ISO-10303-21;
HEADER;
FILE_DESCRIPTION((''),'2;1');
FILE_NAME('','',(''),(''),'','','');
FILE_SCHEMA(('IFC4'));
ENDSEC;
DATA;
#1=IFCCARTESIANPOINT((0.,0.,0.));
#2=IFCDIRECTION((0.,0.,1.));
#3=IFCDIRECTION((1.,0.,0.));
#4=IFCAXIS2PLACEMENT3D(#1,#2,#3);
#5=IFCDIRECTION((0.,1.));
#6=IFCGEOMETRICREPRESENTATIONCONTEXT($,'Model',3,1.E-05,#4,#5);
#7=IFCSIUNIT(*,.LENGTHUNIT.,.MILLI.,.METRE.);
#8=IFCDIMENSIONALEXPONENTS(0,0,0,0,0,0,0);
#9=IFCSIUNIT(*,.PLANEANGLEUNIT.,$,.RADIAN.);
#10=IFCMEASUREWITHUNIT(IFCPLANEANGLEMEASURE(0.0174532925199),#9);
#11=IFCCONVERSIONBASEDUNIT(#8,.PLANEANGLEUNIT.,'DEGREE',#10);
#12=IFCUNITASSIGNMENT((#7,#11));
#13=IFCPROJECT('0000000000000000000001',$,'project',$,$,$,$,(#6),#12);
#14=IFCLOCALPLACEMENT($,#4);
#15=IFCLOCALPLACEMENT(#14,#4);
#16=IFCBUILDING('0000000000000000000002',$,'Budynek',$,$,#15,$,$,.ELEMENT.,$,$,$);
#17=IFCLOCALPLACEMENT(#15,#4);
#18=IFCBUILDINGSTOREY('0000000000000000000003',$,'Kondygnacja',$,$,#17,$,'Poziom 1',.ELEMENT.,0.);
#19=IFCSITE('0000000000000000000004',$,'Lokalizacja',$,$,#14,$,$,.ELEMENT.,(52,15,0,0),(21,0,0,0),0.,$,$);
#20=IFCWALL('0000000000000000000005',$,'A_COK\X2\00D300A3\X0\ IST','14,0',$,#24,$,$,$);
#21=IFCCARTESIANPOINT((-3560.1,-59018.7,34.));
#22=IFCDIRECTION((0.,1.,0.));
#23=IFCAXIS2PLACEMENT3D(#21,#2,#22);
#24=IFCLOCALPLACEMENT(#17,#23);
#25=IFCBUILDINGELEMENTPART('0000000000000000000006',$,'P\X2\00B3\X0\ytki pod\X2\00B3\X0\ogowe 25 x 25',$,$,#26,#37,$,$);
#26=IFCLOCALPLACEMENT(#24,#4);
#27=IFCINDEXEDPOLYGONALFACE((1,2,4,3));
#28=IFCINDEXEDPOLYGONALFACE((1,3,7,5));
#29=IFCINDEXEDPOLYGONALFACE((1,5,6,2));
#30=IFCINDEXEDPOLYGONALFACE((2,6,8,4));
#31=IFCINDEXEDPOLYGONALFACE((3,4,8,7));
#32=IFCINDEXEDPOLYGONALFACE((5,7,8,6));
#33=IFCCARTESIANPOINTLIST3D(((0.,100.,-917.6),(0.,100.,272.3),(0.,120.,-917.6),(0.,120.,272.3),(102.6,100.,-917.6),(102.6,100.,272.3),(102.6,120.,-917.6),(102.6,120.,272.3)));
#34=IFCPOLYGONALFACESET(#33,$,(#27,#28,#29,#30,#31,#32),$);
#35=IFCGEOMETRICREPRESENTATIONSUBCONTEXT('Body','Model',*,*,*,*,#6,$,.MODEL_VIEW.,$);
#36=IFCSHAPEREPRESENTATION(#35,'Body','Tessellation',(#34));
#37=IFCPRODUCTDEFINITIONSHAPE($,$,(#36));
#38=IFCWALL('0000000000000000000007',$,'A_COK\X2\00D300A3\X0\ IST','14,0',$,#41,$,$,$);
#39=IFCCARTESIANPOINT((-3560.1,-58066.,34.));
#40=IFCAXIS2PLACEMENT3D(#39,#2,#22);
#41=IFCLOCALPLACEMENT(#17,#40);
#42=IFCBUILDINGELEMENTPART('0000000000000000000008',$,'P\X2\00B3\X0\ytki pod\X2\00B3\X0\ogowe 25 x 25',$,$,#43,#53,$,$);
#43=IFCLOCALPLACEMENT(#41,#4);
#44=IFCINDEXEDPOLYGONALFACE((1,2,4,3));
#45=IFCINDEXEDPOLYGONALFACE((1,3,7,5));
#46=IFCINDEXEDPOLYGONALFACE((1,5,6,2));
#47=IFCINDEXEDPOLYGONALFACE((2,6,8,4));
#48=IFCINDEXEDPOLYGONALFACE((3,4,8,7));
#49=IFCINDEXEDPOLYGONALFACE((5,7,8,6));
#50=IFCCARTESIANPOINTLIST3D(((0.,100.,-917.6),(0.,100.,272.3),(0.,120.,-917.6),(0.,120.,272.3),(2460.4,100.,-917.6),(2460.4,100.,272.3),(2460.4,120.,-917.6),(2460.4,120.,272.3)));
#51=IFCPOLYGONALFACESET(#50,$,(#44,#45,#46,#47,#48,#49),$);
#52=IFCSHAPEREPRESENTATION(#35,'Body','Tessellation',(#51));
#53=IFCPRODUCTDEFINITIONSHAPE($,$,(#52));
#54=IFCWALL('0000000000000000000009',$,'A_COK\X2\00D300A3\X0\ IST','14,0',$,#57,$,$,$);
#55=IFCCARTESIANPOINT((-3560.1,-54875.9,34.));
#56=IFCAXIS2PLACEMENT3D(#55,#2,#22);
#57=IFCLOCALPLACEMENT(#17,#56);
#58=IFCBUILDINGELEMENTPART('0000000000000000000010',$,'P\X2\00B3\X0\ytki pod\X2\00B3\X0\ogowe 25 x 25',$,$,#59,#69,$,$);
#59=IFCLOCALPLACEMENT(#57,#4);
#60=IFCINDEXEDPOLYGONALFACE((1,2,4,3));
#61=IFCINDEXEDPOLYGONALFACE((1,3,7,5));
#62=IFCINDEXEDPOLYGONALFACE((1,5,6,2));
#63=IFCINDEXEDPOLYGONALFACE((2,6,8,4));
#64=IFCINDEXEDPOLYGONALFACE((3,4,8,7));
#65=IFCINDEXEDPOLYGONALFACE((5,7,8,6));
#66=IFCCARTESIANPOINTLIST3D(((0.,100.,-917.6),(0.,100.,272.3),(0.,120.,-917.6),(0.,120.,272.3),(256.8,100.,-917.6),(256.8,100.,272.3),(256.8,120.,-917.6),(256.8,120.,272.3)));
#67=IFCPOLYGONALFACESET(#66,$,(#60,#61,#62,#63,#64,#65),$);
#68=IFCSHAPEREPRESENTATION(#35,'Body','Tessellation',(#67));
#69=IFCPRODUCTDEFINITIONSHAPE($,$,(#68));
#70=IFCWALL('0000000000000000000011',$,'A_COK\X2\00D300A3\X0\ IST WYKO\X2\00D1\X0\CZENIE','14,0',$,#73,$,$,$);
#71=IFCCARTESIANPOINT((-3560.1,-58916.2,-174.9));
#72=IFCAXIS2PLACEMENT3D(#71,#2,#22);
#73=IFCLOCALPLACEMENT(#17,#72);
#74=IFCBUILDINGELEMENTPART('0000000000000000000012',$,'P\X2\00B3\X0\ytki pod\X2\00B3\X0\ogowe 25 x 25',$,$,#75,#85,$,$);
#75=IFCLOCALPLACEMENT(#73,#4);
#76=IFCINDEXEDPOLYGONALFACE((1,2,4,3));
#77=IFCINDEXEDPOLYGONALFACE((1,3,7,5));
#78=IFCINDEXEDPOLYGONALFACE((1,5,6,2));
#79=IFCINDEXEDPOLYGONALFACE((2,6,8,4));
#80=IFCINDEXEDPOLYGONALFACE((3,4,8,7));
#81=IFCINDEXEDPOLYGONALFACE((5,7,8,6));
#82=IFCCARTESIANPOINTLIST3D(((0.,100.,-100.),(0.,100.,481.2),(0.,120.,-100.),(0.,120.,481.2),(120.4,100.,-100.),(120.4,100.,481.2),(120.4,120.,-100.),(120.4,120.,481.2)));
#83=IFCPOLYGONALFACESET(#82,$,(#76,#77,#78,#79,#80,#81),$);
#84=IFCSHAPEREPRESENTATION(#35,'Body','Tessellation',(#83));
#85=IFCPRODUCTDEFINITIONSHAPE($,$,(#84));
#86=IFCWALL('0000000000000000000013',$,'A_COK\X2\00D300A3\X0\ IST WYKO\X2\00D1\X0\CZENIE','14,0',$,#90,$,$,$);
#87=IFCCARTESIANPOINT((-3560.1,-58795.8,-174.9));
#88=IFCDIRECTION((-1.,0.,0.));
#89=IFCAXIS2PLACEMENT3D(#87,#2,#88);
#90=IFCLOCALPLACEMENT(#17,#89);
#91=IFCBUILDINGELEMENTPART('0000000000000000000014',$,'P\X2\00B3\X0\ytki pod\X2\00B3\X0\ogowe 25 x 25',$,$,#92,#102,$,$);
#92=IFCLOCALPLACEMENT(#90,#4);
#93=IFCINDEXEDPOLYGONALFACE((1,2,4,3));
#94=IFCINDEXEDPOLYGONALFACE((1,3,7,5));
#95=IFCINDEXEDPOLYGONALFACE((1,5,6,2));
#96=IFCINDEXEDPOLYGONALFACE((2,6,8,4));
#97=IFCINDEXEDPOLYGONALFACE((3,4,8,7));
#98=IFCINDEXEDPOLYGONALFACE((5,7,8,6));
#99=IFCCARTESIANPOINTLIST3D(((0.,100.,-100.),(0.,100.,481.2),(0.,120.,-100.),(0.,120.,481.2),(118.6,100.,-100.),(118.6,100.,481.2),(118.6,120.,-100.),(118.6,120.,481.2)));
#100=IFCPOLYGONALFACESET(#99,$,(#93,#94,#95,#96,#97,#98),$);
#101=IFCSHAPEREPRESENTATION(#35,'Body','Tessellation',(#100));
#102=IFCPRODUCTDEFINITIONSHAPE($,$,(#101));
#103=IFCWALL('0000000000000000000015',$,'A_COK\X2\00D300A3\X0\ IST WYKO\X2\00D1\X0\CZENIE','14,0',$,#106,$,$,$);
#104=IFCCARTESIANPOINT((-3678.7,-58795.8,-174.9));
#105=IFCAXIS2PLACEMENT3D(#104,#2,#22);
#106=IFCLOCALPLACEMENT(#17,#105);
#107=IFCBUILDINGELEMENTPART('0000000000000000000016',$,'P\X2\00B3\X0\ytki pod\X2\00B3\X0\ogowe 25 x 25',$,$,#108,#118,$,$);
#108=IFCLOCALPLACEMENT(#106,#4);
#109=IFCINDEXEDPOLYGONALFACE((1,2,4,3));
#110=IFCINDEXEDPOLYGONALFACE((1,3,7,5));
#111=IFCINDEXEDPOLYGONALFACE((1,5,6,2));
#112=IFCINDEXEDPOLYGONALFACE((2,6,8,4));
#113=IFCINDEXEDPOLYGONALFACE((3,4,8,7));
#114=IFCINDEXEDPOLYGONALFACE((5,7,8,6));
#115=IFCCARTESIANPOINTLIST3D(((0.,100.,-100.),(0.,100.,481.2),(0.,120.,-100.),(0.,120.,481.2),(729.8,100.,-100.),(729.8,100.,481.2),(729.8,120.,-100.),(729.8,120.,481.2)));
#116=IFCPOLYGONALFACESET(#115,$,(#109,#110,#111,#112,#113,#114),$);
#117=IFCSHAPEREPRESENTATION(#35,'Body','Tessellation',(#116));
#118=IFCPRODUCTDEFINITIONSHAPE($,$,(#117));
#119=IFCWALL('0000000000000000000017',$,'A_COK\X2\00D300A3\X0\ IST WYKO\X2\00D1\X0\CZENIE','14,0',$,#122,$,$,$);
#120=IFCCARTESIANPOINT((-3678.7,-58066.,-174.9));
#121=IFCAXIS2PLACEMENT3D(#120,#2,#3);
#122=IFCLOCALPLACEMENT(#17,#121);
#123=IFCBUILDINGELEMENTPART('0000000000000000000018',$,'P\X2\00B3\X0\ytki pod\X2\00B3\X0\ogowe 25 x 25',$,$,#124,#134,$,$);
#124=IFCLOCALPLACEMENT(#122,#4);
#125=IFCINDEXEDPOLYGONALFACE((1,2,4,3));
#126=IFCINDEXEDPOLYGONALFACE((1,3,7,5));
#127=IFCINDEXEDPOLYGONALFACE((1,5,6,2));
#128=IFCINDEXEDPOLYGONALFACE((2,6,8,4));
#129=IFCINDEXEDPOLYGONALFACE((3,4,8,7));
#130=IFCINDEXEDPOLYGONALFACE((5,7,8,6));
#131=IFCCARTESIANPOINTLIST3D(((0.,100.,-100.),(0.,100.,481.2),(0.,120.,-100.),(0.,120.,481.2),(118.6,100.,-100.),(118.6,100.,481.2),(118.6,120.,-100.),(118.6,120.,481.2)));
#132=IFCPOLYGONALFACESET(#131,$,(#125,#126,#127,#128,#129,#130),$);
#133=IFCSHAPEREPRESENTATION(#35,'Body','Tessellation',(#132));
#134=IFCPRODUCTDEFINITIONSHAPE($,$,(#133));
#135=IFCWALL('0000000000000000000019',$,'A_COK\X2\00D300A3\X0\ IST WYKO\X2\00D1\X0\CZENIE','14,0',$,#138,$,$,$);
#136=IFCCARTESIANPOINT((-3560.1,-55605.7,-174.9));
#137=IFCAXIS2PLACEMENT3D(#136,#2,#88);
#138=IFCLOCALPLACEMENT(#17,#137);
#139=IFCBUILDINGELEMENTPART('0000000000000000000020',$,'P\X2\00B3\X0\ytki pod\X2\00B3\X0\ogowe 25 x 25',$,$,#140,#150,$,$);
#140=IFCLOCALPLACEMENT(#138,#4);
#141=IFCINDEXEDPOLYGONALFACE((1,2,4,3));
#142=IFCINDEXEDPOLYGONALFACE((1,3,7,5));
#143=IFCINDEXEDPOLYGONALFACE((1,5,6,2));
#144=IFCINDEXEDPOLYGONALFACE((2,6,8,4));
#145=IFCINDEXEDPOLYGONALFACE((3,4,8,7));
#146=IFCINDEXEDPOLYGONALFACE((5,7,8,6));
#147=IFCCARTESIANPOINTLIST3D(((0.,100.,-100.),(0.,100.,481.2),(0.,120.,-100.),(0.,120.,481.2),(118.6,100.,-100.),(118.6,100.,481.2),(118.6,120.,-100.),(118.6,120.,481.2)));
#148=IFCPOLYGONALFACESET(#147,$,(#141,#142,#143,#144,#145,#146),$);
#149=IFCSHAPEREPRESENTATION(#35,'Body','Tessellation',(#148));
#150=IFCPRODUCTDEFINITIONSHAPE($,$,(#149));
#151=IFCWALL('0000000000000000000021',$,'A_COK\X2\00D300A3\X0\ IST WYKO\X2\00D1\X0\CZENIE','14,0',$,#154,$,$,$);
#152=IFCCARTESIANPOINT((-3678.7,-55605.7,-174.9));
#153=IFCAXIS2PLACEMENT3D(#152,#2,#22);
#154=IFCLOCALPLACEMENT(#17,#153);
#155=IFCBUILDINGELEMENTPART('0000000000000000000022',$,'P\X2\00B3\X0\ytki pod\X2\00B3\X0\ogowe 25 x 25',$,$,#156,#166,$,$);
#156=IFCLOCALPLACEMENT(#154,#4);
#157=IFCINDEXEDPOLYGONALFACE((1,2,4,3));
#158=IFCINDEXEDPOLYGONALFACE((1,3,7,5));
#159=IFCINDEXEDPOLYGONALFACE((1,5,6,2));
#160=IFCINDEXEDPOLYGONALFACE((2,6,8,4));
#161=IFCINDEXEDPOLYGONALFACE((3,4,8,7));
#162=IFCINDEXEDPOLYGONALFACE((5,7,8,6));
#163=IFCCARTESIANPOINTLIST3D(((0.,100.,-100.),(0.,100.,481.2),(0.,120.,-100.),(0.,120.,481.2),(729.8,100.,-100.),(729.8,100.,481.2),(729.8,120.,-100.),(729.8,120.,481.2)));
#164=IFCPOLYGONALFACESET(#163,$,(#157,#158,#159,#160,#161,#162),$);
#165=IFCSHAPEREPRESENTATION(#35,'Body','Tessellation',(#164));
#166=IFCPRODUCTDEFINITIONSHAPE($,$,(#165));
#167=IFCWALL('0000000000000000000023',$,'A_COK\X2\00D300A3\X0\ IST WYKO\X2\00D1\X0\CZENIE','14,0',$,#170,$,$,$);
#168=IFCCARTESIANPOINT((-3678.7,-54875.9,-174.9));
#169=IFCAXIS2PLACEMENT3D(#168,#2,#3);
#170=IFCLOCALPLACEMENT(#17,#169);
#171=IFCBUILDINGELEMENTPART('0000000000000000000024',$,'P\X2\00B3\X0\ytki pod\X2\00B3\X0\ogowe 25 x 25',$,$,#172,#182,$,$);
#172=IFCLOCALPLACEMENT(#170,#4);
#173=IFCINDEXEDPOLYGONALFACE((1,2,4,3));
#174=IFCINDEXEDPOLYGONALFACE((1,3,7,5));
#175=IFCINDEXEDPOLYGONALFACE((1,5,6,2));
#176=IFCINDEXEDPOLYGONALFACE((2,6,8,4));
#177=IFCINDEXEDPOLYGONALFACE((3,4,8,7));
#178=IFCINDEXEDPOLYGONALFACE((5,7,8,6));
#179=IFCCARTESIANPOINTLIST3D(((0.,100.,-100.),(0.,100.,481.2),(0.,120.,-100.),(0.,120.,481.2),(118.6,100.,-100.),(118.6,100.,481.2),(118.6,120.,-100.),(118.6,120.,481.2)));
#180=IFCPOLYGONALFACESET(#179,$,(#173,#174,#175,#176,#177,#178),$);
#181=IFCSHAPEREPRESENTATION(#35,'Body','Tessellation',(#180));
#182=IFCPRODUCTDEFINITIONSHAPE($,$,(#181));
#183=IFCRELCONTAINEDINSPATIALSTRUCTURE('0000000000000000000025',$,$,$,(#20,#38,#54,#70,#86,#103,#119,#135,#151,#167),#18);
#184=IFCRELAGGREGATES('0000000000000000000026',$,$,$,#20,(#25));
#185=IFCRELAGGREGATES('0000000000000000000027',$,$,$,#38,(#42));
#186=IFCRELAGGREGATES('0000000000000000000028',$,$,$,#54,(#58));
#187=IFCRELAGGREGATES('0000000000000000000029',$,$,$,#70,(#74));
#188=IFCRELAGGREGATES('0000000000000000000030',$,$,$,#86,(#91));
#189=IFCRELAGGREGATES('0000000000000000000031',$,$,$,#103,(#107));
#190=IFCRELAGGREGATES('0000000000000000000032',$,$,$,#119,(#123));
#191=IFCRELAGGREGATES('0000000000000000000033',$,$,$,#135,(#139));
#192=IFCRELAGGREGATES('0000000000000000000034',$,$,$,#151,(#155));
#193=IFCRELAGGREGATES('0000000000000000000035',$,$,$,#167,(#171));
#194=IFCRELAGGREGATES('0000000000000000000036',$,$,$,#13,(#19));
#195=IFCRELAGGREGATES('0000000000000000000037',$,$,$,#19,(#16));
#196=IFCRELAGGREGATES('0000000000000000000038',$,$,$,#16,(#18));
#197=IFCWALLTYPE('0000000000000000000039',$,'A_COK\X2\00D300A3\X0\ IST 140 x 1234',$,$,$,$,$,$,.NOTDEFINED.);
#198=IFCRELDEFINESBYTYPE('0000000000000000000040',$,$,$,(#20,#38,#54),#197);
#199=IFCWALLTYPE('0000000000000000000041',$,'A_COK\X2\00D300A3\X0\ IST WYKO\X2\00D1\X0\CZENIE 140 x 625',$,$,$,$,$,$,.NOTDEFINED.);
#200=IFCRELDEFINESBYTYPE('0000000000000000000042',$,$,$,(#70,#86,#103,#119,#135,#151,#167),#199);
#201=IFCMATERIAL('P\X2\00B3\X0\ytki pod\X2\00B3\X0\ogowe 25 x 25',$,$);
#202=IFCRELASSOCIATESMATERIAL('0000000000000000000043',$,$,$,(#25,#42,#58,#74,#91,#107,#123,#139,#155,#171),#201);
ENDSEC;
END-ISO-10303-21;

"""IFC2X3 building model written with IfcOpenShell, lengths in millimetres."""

from ifc_helpers import new_model, entity, si_unit, converted_unit, direction, frame, origin_with_axes, place, context, subcontext, project, spatial, polyline, outline, extrude, material, type_object, element, aggregate, save


model = new_model("IFC2X3")

# Units and contexts
model_context = context("Model", 3, precision=1e-05, world=origin_with_axes(), true_north=direction((0.0, 1.0)))
body_context = subcontext(model_context, "Body", "Model", "MODEL_VIEW")
ifc_project = project(units=[si_unit("LENGTHUNIT", "METRE", prefix="MILLI"), converted_unit("PLANEANGLEUNIT", "DEGREE", entity("IfcPlaneAngleMeasure", 0.0174532925199), si_unit("PLANEANGLEUNIT", "RADIAN"), dimensions=[0, 0, 0, 0, 0, 0, 0])], contexts=[model_context])

# Site, building, storey
site_placement = place(None, origin_with_axes())
site = spatial("IfcSite", under=ifc_project, at=site_placement, Name="Lokalizacja", CompositionType="ELEMENT", RefLatitude=(52, 15, 0, 0), RefLongitude=(21, 0, 0, 0), RefElevation=0.0)
building_placement = place(site_placement, origin_with_axes())
building = spatial("IfcBuilding", under=site, at=building_placement, Name="Budynek", CompositionType="ELEMENT")
storey_placement = place(building_placement, origin_with_axes())
storey = spatial("IfcBuildingStorey", under=building, at=storey_placement, Name="Kondygnacja", LongName="Poziom 1", CompositionType="ELEMENT", Elevation=0.0)

# Walls, building element parts
wall_type_1 = type_object("IfcWallType", Name="A_COKÓ£ IST 140 x 1234", PredefinedType="NOTDEFINED")
wall_1_placement = place(storey_placement, frame((-3560.1, -59018.7, 34.0), z_axis=(0.0, 0.0, 1.0), x_axis=(0.0, 1.0, 0.0)))
wall_1 = element("IfcWall", 1, at=wall_1_placement, inside=storey, type_object=wall_type_1, Name="A_COKÓ£ IST", Description="14,0")
ifc_material_1 = material(Name="P³ytki pod³ogowe 25 x 25")
building_element_part_1_placement = place(wall_1_placement, origin_with_axes())
building_element_part_1 = element("IfcBuildingElementPart", 2, at=building_element_part_1_placement, material=ifc_material_1, Name="P³ytki pod³ogowe 25 x 25", context=body_context, shape_type="SweptSolid", body=[
    extrude(outline(polyline([(-100.0, -917.6), (-100.0, 272.3), (-120.0, 272.3), (-120.0, -917.6), (-100.0, -917.6)])), frame((0.0, 0.0, 0.0), z_axis=(-1.0, 0.0, 0.0), x_axis=(0.0, -1.0, 0.0)), (0.0, 0.0, -1.0), 102.6),
])
aggregate(wall_1, [building_element_part_1])
wall_2_placement = place(storey_placement, frame((-3560.1, -58066.0, 34.0), z_axis=(0.0, 0.0, 1.0), x_axis=(0.0, 1.0, 0.0)))
wall_2 = element("IfcWall", 3, at=wall_2_placement, inside=storey, type_object=wall_type_1, Name="A_COKÓ£ IST", Description="14,0")
building_element_part_2_placement = place(wall_2_placement, origin_with_axes())
building_element_part_2 = element("IfcBuildingElementPart", 4, at=building_element_part_2_placement, material=ifc_material_1, Name="P³ytki pod³ogowe 25 x 25", context=body_context, shape_type="SweptSolid", body=[
    extrude(outline(polyline([(-100.0, -917.6), (-100.0, 272.3), (-120.0, 272.3), (-120.0, -917.6), (-100.0, -917.6)])), frame((0.0, 0.0, 0.0), z_axis=(-1.0, 0.0, 0.0), x_axis=(0.0, -1.0, 0.0)), (0.0, 0.0, -1.0), 2460.4),
])
aggregate(wall_2, [building_element_part_2])
wall_3_placement = place(storey_placement, frame((-3560.1, -54875.9, 34.0), z_axis=(0.0, 0.0, 1.0), x_axis=(0.0, 1.0, 0.0)))
wall_3 = element("IfcWall", 5, at=wall_3_placement, inside=storey, type_object=wall_type_1, Name="A_COKÓ£ IST", Description="14,0")
building_element_part_3_placement = place(wall_3_placement, origin_with_axes())
building_element_part_3 = element("IfcBuildingElementPart", 6, at=building_element_part_3_placement, material=ifc_material_1, Name="P³ytki pod³ogowe 25 x 25", context=body_context, shape_type="SweptSolid", body=[
    extrude(outline(polyline([(-100.0, -917.6), (-100.0, 272.3), (-120.0, 272.3), (-120.0, -917.6), (-100.0, -917.6)])), frame((0.0, 0.0, 0.0), z_axis=(-1.0, 0.0, 0.0), x_axis=(0.0, -1.0, 0.0)), (0.0, 0.0, -1.0), 256.8),
])
aggregate(wall_3, [building_element_part_3])
wall_type_2 = type_object("IfcWallType", Name="A_COKÓ£ IST WYKOÑCZENIE 140 x 625", PredefinedType="NOTDEFINED")
wall_4_placement = place(storey_placement, frame((-3560.1, -58916.2, -174.9), z_axis=(0.0, 0.0, 1.0), x_axis=(0.0, 1.0, 0.0)))
wall_4 = element("IfcWall", 7, at=wall_4_placement, inside=storey, type_object=wall_type_2, Name="A_COKÓ£ IST WYKOÑCZENIE", Description="14,0")
building_element_part_4_placement = place(wall_4_placement, origin_with_axes())
building_element_part_4 = element("IfcBuildingElementPart", 8, at=building_element_part_4_placement, material=ifc_material_1, Name="P³ytki pod³ogowe 25 x 25", context=body_context, shape_type="SweptSolid", body=[
    extrude(outline(polyline([(-100.0, -100.0), (-100.0, 481.2), (-120.0, 481.2), (-120.0, -100.0), (-100.0, -100.0)])), frame((0.0, 0.0, 0.0), z_axis=(-1.0, 0.0, 0.0), x_axis=(0.0, -1.0, 0.0)), (0.0, 0.0, -1.0), 120.4),
])
aggregate(wall_4, [building_element_part_4])
wall_5_placement = place(storey_placement, frame((-3560.1, -58795.8, -174.9), z_axis=(0.0, 0.0, 1.0), x_axis=(-1.0, 0.0, 0.0)))
wall_5 = element("IfcWall", 9, at=wall_5_placement, inside=storey, type_object=wall_type_2, Name="A_COKÓ£ IST WYKOÑCZENIE", Description="14,0")
building_element_part_5_placement = place(wall_5_placement, origin_with_axes())
building_element_part_5 = element("IfcBuildingElementPart", 10, at=building_element_part_5_placement, material=ifc_material_1, Name="P³ytki pod³ogowe 25 x 25", context=body_context, shape_type="SweptSolid", body=[
    extrude(outline(polyline([(-100.0, -100.0), (-100.0, 481.2), (-120.0, 481.2), (-120.0, -100.0), (-100.0, -100.0)])), frame((0.0, 0.0, 0.0), z_axis=(-1.0, 0.0, 0.0), x_axis=(0.0, -1.0, 0.0)), (0.0, 0.0, -1.0), 118.6),
])
aggregate(wall_5, [building_element_part_5])
wall_6_placement = place(storey_placement, frame((-3678.7, -58795.8, -174.9), z_axis=(0.0, 0.0, 1.0), x_axis=(0.0, 1.0, 0.0)))
wall_6 = element("IfcWall", 11, at=wall_6_placement, inside=storey, type_object=wall_type_2, Name="A_COKÓ£ IST WYKOÑCZENIE", Description="14,0")
building_element_part_6_placement = place(wall_6_placement, origin_with_axes())
building_element_part_6 = element("IfcBuildingElementPart", 12, at=building_element_part_6_placement, material=ifc_material_1, Name="P³ytki pod³ogowe 25 x 25", context=body_context, shape_type="SweptSolid", body=[
    extrude(outline(polyline([(-100.0, -100.0), (-100.0, 481.2), (-120.0, 481.2), (-120.0, -100.0), (-100.0, -100.0)])), frame((0.0, 0.0, 0.0), z_axis=(-1.0, 0.0, 0.0), x_axis=(0.0, -1.0, 0.0)), (0.0, 0.0, -1.0), 729.8),
])
aggregate(wall_6, [building_element_part_6])
wall_7_placement = place(storey_placement, frame((-3678.7, -58066.0, -174.9), z_axis=(0.0, 0.0, 1.0), x_axis=(1.0, 0.0, 0.0)))
wall_7 = element("IfcWall", 13, at=wall_7_placement, inside=storey, type_object=wall_type_2, Name="A_COKÓ£ IST WYKOÑCZENIE", Description="14,0")
building_element_part_7_placement = place(wall_7_placement, origin_with_axes())
building_element_part_7 = element("IfcBuildingElementPart", 14, at=building_element_part_7_placement, material=ifc_material_1, Name="P³ytki pod³ogowe 25 x 25", context=body_context, shape_type="SweptSolid", body=[
    extrude(outline(polyline([(-100.0, -100.0), (-100.0, 481.2), (-120.0, 481.2), (-120.0, -100.0), (-100.0, -100.0)])), frame((0.0, 0.0, 0.0), z_axis=(-1.0, 0.0, 0.0), x_axis=(0.0, -1.0, 0.0)), (0.0, 0.0, -1.0), 118.6),
])
aggregate(wall_7, [building_element_part_7])
wall_8_placement = place(storey_placement, frame((-3560.1, -55605.7, -174.9), z_axis=(0.0, 0.0, 1.0), x_axis=(-1.0, 0.0, 0.0)))
wall_8 = element("IfcWall", 15, at=wall_8_placement, inside=storey, type_object=wall_type_2, Name="A_COKÓ£ IST WYKOÑCZENIE", Description="14,0")
building_element_part_8_placement = place(wall_8_placement, origin_with_axes())
building_element_part_8 = element("IfcBuildingElementPart", 16, at=building_element_part_8_placement, material=ifc_material_1, Name="P³ytki pod³ogowe 25 x 25", context=body_context, shape_type="SweptSolid", body=[
    extrude(outline(polyline([(-100.0, -100.0), (-100.0, 481.2), (-120.0, 481.2), (-120.0, -100.0), (-100.0, -100.0)])), frame((0.0, 0.0, 0.0), z_axis=(-1.0, 0.0, 0.0), x_axis=(0.0, -1.0, 0.0)), (0.0, 0.0, -1.0), 118.6),
])
aggregate(wall_8, [building_element_part_8])
wall_9_placement = place(storey_placement, frame((-3678.7, -55605.7, -174.9), z_axis=(0.0, 0.0, 1.0), x_axis=(0.0, 1.0, 0.0)))
wall_9 = element("IfcWall", 17, at=wall_9_placement, inside=storey, type_object=wall_type_2, Name="A_COKÓ£ IST WYKOÑCZENIE", Description="14,0")
building_element_part_9_placement = place(wall_9_placement, origin_with_axes())
building_element_part_9 = element("IfcBuildingElementPart", 18, at=building_element_part_9_placement, material=ifc_material_1, Name="P³ytki pod³ogowe 25 x 25", context=body_context, shape_type="SweptSolid", body=[
    extrude(outline(polyline([(-100.0, -100.0), (-100.0, 481.2), (-120.0, 481.2), (-120.0, -100.0), (-100.0, -100.0)])), frame((0.0, 0.0, 0.0), z_axis=(-1.0, 0.0, 0.0), x_axis=(0.0, -1.0, 0.0)), (0.0, 0.0, -1.0), 729.8),
])
aggregate(wall_9, [building_element_part_9])
wall_10_placement = place(storey_placement, frame((-3678.7, -54875.9, -174.9), z_axis=(0.0, 0.0, 1.0), x_axis=(1.0, 0.0, 0.0)))
wall_10 = element("IfcWall", 19, at=wall_10_placement, inside=storey, type_object=wall_type_2, Name="A_COKÓ£ IST WYKOÑCZENIE", Description="14,0")
building_element_part_10_placement = place(wall_10_placement, origin_with_axes())
building_element_part_10 = element("IfcBuildingElementPart", 20, at=building_element_part_10_placement, material=ifc_material_1, Name="P³ytki pod³ogowe 25 x 25", context=body_context, shape_type="SweptSolid", body=[
    extrude(outline(polyline([(-100.0, -100.0), (-100.0, 481.2), (-120.0, 481.2), (-120.0, -100.0), (-100.0, -100.0)])), frame((0.0, 0.0, 0.0), z_axis=(-1.0, 0.0, 0.0), x_axis=(0.0, -1.0, 0.0)), (0.0, 0.0, -1.0), 118.6),
])
aggregate(wall_10, [building_element_part_10])

save(model, "model.ifc")
